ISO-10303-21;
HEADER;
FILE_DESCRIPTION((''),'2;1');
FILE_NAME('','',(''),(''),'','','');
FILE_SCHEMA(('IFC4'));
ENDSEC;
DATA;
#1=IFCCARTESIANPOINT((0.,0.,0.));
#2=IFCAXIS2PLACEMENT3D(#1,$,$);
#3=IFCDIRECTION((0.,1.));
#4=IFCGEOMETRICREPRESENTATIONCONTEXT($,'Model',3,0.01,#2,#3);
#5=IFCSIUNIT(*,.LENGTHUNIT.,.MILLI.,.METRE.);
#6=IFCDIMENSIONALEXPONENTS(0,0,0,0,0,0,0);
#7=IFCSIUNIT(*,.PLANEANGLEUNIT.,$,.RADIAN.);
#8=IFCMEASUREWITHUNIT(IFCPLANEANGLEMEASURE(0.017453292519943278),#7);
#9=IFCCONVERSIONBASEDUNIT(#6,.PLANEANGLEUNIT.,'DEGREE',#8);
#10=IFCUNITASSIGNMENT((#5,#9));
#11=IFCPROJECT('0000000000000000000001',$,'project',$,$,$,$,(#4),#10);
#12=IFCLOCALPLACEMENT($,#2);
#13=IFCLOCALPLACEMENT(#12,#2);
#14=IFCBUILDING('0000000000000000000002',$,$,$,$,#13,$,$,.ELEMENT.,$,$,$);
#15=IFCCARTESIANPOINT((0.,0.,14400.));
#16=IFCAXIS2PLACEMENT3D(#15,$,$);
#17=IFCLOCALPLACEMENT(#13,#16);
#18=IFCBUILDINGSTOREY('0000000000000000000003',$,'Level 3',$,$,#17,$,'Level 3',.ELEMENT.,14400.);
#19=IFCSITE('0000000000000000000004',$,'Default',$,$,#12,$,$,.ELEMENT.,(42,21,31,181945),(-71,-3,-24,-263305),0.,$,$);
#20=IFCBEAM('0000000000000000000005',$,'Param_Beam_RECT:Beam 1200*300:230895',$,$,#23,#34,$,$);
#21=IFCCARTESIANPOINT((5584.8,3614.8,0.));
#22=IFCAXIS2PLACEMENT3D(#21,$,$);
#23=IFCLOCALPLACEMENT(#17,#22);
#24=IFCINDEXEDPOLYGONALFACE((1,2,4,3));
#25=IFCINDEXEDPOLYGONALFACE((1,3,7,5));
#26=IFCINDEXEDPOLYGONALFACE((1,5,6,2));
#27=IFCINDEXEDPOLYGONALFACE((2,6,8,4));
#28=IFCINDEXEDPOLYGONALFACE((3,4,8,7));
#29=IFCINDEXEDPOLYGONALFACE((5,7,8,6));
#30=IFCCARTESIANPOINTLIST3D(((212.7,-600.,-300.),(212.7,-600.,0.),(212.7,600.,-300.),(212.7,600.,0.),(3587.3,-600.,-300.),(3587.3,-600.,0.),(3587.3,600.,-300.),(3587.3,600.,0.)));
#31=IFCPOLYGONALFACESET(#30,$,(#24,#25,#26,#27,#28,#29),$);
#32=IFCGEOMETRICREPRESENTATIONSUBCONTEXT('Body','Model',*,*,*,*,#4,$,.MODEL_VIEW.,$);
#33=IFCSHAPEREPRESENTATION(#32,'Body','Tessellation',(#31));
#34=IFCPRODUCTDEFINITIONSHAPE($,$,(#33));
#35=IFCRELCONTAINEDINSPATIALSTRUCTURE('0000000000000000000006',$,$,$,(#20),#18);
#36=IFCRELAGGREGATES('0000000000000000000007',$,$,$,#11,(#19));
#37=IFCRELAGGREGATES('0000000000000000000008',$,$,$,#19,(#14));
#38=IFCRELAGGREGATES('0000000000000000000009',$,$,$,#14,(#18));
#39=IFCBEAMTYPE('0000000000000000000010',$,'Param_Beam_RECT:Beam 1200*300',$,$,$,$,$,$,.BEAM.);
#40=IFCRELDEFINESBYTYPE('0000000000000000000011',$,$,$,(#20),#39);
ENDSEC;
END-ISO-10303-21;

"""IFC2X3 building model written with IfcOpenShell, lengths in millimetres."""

from ifc_helpers import new_model, entity, si_unit, converted_unit, direction, frame, frame_2d, origin, place, context, subcontext, project, spatial, rectangle, extrude, type_object, element, save


model = new_model("IFC2X3")

# Units and contexts
model_context = context("Model", 3, precision=0.01, world=origin(), true_north=direction((0.0, 1.0)))
body_context = subcontext(model_context, "Body", "Model", "MODEL_VIEW")
ifc_project = project(units=[si_unit("LENGTHUNIT", "METRE", prefix="MILLI"), converted_unit("PLANEANGLEUNIT", "DEGREE", entity("IfcPlaneAngleMeasure", 0.017453292519943278), si_unit("PLANEANGLEUNIT", "RADIAN"), dimensions=[0, 0, 0, 0, 0, 0, 0])], contexts=[model_context])

# Site, building, storey
site_placement = place(None, origin())
site = spatial("IfcSite", under=ifc_project, at=site_placement, Name="Default", CompositionType="ELEMENT", RefLatitude=(42, 21, 31, 181945), RefLongitude=(-71, -3, -24, -263305), RefElevation=0.0)
building_placement = place(site_placement, origin())
building = spatial("IfcBuilding", under=site, at=building_placement, CompositionType="ELEMENT")
storey_placement = place(building_placement, frame((0.0, 0.0, 14400.0)))
storey = spatial("IfcBuildingStorey", under=building, at=storey_placement, Name="Level 3", LongName="Level 3", CompositionType="ELEMENT", Elevation=14400.0)

# Beam
beam_type_1 = type_object("IfcBeamType", Name="Param_Beam_RECT:Beam 1200*300", PredefinedType="BEAM")
beam_1_placement = place(storey_placement, frame((5584.8, 3614.8, 0.0)))
element("IfcBeam", 1, at=beam_1_placement, inside=storey, type_object=beam_type_1, Name="Param_Beam_RECT:Beam 1200*300:230895", context=body_context, shape_type="SweptSolid", body=[
    extrude(rectangle(XDim=300.0, YDim=1200.0, at=frame_2d((0.0, 0.0), x_axis=(1.0, 0.0))), frame((212.7, 0.0, -150.0), z_axis=(1.0, 0.0, 0.0), x_axis=(0.0, 0.0, -1.0)), (0.0, 0.0, 1.0), 3374.6),
])

save(model, "model.ifc")
